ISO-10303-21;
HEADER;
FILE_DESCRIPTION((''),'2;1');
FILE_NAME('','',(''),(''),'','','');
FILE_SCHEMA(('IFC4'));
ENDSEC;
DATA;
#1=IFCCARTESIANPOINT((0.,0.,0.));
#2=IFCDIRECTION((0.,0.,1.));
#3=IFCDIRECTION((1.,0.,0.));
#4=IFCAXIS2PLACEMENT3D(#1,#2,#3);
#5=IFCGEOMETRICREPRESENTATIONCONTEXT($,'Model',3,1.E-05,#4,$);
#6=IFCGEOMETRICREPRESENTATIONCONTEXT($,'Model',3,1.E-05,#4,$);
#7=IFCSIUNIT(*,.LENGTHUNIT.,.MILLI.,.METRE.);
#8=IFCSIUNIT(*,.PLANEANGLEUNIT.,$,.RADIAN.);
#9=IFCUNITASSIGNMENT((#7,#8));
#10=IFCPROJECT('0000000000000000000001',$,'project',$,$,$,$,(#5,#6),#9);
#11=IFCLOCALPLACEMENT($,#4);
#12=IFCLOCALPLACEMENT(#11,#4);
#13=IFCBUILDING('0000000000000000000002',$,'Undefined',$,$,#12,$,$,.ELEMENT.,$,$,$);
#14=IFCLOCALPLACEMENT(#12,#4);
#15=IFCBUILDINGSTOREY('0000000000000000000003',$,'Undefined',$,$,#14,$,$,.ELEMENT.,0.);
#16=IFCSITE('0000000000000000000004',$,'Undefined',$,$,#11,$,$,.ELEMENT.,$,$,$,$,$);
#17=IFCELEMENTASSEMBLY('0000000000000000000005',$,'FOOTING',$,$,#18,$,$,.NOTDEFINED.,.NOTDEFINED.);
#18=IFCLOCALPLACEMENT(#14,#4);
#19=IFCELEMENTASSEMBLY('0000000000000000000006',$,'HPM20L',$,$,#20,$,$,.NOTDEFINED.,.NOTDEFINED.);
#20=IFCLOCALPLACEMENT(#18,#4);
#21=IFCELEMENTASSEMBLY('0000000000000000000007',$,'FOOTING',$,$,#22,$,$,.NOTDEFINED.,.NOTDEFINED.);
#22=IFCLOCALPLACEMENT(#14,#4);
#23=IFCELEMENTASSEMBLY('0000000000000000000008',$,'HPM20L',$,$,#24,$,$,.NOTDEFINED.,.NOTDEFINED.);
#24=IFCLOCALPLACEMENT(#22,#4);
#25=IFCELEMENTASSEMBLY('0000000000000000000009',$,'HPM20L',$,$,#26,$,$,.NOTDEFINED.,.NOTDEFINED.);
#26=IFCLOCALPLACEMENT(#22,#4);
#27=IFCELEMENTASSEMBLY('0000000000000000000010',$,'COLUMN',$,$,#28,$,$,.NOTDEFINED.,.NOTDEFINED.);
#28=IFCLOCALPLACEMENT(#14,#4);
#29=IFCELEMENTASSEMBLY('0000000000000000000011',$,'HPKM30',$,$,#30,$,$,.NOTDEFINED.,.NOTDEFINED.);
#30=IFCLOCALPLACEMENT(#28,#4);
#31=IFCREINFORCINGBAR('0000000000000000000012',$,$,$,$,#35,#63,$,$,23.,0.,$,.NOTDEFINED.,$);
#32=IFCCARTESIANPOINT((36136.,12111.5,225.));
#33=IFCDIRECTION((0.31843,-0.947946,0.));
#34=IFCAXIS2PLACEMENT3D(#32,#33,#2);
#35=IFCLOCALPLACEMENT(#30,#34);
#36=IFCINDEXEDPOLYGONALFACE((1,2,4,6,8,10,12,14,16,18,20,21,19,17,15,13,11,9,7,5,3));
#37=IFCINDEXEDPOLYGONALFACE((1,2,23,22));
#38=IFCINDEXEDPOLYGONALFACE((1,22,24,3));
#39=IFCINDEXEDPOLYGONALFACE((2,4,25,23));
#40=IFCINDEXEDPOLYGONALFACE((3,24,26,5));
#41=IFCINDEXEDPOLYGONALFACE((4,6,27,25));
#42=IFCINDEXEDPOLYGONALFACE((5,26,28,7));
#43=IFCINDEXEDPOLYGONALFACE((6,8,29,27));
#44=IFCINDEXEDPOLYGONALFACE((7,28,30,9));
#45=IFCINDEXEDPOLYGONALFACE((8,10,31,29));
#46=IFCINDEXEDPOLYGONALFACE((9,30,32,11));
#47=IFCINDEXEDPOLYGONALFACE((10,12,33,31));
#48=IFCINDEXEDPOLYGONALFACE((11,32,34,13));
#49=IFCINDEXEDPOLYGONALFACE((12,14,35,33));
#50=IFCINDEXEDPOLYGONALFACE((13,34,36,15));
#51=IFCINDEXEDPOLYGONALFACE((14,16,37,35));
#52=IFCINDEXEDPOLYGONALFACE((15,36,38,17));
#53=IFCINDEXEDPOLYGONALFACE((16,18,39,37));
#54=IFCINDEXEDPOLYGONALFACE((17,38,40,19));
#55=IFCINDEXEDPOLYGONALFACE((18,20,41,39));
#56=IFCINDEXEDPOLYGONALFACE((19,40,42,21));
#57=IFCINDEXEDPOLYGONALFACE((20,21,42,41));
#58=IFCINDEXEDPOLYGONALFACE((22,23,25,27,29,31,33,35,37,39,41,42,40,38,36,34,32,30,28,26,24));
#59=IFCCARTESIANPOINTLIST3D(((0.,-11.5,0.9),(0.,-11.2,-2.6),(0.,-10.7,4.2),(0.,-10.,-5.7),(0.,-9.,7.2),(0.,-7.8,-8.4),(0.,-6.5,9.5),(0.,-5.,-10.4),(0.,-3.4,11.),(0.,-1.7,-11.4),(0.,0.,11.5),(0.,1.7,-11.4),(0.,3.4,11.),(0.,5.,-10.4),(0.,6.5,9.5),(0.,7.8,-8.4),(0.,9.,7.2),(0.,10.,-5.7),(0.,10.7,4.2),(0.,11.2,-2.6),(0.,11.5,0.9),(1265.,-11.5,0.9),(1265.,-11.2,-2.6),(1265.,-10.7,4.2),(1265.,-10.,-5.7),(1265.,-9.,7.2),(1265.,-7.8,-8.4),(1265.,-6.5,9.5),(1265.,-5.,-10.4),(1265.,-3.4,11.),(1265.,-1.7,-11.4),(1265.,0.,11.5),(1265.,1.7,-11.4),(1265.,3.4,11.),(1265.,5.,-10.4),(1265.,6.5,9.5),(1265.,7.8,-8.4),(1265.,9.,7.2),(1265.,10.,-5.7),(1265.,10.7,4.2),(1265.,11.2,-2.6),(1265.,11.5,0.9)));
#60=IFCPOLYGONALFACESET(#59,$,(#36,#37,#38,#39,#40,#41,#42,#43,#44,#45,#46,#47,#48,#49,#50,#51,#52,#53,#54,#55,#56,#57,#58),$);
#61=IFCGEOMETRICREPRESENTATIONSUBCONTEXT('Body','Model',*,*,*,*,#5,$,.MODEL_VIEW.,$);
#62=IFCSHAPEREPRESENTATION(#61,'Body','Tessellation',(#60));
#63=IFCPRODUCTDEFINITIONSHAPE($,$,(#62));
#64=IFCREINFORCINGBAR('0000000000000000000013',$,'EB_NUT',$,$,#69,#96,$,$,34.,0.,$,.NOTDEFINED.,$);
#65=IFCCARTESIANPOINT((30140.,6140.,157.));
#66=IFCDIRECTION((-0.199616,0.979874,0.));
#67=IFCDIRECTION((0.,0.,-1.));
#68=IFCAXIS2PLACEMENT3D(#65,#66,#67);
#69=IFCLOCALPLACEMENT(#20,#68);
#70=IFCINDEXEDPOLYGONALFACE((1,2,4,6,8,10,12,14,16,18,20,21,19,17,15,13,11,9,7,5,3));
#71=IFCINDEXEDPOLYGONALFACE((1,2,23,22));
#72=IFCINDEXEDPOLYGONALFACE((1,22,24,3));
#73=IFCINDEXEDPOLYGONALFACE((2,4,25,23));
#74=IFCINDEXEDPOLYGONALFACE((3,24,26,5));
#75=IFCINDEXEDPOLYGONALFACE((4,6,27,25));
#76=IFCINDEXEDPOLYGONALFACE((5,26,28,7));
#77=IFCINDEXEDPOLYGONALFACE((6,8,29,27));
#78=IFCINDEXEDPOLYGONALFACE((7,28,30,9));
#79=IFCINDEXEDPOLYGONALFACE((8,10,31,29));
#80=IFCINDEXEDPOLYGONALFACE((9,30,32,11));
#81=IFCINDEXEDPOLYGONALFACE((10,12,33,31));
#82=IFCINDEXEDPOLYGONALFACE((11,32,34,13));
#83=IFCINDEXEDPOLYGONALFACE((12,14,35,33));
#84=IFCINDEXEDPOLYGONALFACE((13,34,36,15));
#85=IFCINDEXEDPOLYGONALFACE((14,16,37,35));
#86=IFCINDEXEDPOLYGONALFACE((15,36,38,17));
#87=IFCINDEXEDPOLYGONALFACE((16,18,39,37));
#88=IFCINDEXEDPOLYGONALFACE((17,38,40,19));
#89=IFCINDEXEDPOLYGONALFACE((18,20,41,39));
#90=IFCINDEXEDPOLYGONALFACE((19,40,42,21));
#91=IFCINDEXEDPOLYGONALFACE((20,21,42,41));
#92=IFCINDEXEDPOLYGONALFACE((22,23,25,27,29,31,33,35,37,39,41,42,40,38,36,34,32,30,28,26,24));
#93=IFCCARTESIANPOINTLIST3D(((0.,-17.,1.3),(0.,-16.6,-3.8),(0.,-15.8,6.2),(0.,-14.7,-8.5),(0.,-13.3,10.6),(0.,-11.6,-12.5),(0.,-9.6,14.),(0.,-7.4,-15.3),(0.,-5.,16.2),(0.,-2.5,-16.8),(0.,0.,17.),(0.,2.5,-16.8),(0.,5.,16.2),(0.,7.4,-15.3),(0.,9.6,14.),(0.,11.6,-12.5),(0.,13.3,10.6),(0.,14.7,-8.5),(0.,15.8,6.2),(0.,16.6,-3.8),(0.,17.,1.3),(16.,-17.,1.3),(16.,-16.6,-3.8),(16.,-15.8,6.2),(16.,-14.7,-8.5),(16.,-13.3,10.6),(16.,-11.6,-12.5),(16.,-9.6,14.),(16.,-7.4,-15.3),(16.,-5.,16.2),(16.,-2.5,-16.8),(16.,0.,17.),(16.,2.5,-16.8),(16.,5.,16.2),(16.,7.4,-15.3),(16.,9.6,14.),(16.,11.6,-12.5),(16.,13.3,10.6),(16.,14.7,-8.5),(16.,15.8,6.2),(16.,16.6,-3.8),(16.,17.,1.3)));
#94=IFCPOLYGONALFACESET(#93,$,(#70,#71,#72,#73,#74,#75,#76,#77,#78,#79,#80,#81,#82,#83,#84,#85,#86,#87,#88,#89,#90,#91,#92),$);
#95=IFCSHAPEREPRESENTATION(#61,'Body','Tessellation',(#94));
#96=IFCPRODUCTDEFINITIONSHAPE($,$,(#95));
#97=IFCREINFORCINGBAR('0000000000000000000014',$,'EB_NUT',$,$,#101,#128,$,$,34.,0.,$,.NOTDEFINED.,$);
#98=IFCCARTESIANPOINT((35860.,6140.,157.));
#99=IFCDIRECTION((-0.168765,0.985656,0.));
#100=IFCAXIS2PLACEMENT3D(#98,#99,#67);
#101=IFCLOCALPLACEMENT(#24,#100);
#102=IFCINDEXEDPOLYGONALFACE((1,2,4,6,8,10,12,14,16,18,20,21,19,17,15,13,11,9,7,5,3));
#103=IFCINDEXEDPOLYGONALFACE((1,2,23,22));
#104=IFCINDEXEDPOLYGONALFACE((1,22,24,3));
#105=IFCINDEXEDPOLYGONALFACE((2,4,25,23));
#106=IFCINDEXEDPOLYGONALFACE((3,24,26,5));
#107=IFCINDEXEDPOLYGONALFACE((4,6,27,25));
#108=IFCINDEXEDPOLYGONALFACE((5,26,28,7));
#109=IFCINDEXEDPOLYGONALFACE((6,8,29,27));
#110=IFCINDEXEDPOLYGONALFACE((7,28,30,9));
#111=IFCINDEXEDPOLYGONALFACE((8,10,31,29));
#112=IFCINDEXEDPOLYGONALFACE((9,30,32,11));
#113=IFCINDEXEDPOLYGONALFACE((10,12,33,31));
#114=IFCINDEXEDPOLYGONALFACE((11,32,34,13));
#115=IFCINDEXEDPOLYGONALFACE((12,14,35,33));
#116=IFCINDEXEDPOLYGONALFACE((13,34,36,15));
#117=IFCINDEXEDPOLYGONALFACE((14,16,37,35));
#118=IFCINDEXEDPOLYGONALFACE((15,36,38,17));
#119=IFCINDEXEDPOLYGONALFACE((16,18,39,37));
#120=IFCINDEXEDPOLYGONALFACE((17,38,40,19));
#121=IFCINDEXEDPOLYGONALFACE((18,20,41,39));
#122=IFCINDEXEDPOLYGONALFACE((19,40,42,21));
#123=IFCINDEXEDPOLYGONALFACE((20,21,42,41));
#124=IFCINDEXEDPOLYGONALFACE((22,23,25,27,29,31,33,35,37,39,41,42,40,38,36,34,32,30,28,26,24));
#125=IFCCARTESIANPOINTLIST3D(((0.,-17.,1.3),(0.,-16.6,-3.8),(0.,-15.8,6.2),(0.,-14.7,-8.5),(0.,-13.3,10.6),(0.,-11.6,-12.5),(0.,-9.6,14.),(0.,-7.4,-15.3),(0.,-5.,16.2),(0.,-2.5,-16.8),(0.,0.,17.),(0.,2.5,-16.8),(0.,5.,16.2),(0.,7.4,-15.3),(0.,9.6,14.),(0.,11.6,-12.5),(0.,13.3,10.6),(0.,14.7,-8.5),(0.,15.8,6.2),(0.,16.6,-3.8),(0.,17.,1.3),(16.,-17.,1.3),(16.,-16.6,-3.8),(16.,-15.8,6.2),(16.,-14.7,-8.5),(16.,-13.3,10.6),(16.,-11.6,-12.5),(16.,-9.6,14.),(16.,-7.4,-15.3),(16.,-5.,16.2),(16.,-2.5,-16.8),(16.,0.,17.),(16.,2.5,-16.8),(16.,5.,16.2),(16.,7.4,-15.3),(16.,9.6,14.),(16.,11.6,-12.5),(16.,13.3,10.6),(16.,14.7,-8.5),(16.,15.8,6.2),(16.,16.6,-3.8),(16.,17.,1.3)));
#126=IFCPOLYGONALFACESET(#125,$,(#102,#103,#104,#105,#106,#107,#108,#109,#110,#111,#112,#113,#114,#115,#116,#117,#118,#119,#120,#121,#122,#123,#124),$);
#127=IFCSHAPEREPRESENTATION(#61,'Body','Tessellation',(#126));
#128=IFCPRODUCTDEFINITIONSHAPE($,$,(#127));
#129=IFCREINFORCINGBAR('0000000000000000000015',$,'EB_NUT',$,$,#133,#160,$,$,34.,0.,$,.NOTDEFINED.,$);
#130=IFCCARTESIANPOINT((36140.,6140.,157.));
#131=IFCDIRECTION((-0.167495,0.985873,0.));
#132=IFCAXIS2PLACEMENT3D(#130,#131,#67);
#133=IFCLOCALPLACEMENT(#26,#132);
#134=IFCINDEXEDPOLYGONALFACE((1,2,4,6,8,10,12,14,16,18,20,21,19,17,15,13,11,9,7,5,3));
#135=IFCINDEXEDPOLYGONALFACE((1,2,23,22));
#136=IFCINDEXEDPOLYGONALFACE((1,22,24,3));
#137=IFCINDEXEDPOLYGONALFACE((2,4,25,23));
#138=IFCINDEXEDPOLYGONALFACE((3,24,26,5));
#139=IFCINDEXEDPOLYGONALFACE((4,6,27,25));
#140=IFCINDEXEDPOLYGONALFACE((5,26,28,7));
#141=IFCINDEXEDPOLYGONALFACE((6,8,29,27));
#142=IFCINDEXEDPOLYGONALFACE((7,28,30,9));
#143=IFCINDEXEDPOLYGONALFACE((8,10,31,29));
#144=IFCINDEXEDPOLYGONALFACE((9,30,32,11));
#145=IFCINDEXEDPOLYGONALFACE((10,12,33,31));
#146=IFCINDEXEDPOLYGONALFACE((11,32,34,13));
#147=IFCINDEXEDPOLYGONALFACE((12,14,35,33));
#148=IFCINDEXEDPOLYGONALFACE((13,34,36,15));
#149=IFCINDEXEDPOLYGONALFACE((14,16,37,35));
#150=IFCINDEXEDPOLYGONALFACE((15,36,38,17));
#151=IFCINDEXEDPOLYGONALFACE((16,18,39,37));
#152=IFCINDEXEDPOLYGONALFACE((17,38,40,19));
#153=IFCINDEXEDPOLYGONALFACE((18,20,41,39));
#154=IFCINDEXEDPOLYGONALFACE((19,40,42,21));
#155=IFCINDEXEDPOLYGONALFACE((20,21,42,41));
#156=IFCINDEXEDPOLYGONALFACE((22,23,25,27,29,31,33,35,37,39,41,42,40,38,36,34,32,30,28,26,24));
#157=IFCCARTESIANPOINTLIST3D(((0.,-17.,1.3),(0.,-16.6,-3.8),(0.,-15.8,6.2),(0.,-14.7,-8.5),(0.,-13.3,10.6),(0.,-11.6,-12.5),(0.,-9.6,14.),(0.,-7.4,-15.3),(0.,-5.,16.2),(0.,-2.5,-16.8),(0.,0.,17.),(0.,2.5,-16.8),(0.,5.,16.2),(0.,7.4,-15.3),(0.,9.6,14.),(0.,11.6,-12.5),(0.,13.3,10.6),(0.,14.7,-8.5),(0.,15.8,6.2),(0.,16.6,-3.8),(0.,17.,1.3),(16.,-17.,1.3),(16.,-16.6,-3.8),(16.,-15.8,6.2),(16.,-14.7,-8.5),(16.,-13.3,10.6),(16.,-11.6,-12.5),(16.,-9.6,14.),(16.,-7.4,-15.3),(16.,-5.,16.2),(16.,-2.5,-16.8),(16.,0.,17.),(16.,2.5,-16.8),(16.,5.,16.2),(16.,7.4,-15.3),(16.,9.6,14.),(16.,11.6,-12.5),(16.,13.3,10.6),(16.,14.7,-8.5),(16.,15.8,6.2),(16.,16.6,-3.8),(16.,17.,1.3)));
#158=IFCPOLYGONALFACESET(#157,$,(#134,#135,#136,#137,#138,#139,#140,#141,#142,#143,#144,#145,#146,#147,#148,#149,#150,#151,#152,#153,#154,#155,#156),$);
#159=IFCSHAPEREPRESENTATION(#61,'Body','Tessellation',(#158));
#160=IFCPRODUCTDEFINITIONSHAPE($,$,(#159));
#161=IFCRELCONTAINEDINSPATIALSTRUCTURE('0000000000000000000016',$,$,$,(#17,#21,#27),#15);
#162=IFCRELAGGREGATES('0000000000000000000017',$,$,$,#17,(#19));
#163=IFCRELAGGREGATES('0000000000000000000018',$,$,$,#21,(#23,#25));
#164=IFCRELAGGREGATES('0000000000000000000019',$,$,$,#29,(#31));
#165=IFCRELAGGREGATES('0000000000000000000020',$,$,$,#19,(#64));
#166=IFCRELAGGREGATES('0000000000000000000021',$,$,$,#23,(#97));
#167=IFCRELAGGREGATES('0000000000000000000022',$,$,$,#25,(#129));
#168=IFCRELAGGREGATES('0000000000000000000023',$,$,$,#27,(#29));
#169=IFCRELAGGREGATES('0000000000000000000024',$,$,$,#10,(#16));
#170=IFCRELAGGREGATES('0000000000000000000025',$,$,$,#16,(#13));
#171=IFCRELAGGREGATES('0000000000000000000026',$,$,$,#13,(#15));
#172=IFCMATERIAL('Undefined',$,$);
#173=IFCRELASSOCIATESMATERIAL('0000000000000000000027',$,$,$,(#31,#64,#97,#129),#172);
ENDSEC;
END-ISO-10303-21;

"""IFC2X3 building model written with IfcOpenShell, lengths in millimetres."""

from ifc_helpers import new_model, entity, si_unit, frame, origin_with_axes, place, context, subcontext, project, spatial, source, transform, mapped, material, element, aggregate, save


model = new_model("IFC2X3")

# Units and contexts
model_context_1 = context("Model", 3, precision=1e-05, world=origin_with_axes())
model_context_2 = context("Model", 3, precision=1e-05, world=origin_with_axes())
body_context = subcontext(model_context_1, "Body", "Model", "MODEL_VIEW")
ifc_project = project(units=[si_unit("LENGTHUNIT", "METRE", prefix="MILLI"), si_unit("PLANEANGLEUNIT", "RADIAN")], contexts=[model_context_1, model_context_2])

# Site, building, storey
site_placement = place(None, origin_with_axes())
site = spatial("IfcSite", under=ifc_project, at=site_placement, Name="Undefined", CompositionType="ELEMENT")
building_placement = place(site_placement, origin_with_axes())
building = spatial("IfcBuilding", under=site, at=building_placement, Name="Undefined", CompositionType="ELEMENT")
storey_placement = place(building_placement, origin_with_axes())
storey = spatial("IfcBuildingStorey", under=building, at=storey_placement, Name="Undefined", CompositionType="ELEMENT", Elevation=0.0)

# Element assemblies
assembly_1_placement = place(storey_placement, origin_with_axes())
assembly_1 = element("IfcElementAssembly", 1, at=assembly_1_placement, inside=storey, Name="FOOTING", AssemblyPlace="NOTDEFINED", PredefinedType="NOTDEFINED")
assembly_2_placement = place(assembly_1_placement, origin_with_axes())
assembly_2 = element("IfcElementAssembly", 2, at=assembly_2_placement, Name="HPM20L", AssemblyPlace="NOTDEFINED", PredefinedType="NOTDEFINED")
aggregate(assembly_1, [assembly_2])

# Element assemblies
assembly_3_placement = place(storey_placement, origin_with_axes())
assembly_3 = element("IfcElementAssembly", 3, at=assembly_3_placement, inside=storey, Name="FOOTING", AssemblyPlace="NOTDEFINED", PredefinedType="NOTDEFINED")
assembly_4_placement = place(assembly_3_placement, origin_with_axes())
assembly_4 = element("IfcElementAssembly", 4, at=assembly_4_placement, Name="HPM20L", AssemblyPlace="NOTDEFINED", PredefinedType="NOTDEFINED")
assembly_5_placement = place(assembly_3_placement, origin_with_axes())
assembly_5 = element("IfcElementAssembly", 5, at=assembly_5_placement, Name="HPM20L", AssemblyPlace="NOTDEFINED", PredefinedType="NOTDEFINED")
aggregate(assembly_3, [assembly_4, assembly_5])

# Element assembly
assembly_6_placement = place(storey_placement, origin_with_axes())
assembly_6 = element("IfcElementAssembly", 6, at=assembly_6_placement, inside=storey, Name="COLUMN", AssemblyPlace="NOTDEFINED", PredefinedType="NOTDEFINED")
ifc_material_1 = material(Name="Undefined")

# Element assembly, reinforcing bar
assembly_7_placement = place(assembly_6_placement, origin_with_axes())
assembly_7 = element("IfcElementAssembly", 7, at=assembly_7_placement, Name="HPKM30", AssemblyPlace="NOTDEFINED", PredefinedType="NOTDEFINED")
shared_shape_1 = source(origin_with_axes(), body_context, "Body", "AdvancedSweptSolid", [
    entity("IfcSweptDiskSolid", entity("IfcTrimmedCurve", entity("IfcLine", entity("IfcCartesianPoint", [0.0, 0.0, 0.0]), entity("IfcVector", entity("IfcDirection", [1.0, 0.0, 0.0]), 1.0)), [entity("IfcParameterValue", 0.0)], [entity("IfcParameterValue", 1265.0)], True, "PARAMETER"), 11.5, None, 0.0, 1265.0),
])
reinforcing_bar_1_placement = place(assembly_7_placement, frame((36136.0, 12111.5, 225.0), z_axis=(0.31843, -0.947946, 0.0), x_axis=(0.0, 0.0, 1.0)))
reinforcing_bar_1 = element("IfcReinforcingBar", 8, at=reinforcing_bar_1_placement, material=ifc_material_1, BarRole="NOTDEFINED", CrossSectionArea=0.0, NominalDiameter=23.0, context=body_context, shape_type="MappedRepresentation", body=[
    mapped(shared_shape_1, transform((0.0, 0.0, 0.0))),
])
aggregate(assembly_7, [reinforcing_bar_1])

# Reinforcing bars
shared_shape_2 = source(origin_with_axes(), body_context, "Body", "AdvancedSweptSolid", [
    entity("IfcSweptDiskSolid", entity("IfcTrimmedCurve", entity("IfcLine", entity("IfcCartesianPoint", [0.0, 0.0, 0.0]), entity("IfcVector", entity("IfcDirection", [1.0, 0.0, 0.0]), 1.0)), [entity("IfcParameterValue", 0.0)], [entity("IfcParameterValue", 16.0)], True, "PARAMETER"), 17.0, None, 0.0, 16.0),
])
reinforcing_bar_2_placement = place(assembly_2_placement, frame((30140.0, 6140.0, 157.0), z_axis=(-0.199616, 0.979874, 0.0), x_axis=(0.0, 0.0, -1.0)))
reinforcing_bar_2 = element("IfcReinforcingBar", 9, at=reinforcing_bar_2_placement, material=ifc_material_1, Name="EB_NUT", BarRole="NOTDEFINED", CrossSectionArea=0.0, NominalDiameter=34.0, context=body_context, shape_type="MappedRepresentation", body=[
    mapped(shared_shape_2, transform((0.0, 0.0, 0.0))),
])
aggregate(assembly_2, [reinforcing_bar_2])
shared_shape_3 = source(origin_with_axes(), body_context, "Body", "AdvancedSweptSolid", [
    entity("IfcSweptDiskSolid", entity("IfcTrimmedCurve", entity("IfcLine", entity("IfcCartesianPoint", [0.0, 0.0, 0.0]), entity("IfcVector", entity("IfcDirection", [1.0, 0.0, 0.0]), 1.0)), [entity("IfcParameterValue", 0.0)], [entity("IfcParameterValue", 16.0)], True, "PARAMETER"), 17.0, None, 0.0, 16.0),
])
reinforcing_bar_3_placement = place(assembly_4_placement, frame((35860.0, 6140.0, 157.0), z_axis=(-0.168765, 0.985656, 0.0), x_axis=(0.0, 0.0, -1.0)))
reinforcing_bar_3 = element("IfcReinforcingBar", 10, at=reinforcing_bar_3_placement, material=ifc_material_1, Name="EB_NUT", BarRole="NOTDEFINED", CrossSectionArea=0.0, NominalDiameter=34.0, context=body_context, shape_type="MappedRepresentation", body=[
    mapped(shared_shape_3, transform((0.0, 0.0, 0.0))),
])
aggregate(assembly_4, [reinforcing_bar_3])
shared_shape_4 = source(origin_with_axes(), body_context, "Body", "AdvancedSweptSolid", [
    entity("IfcSweptDiskSolid", entity("IfcTrimmedCurve", entity("IfcLine", entity("IfcCartesianPoint", [0.0, 0.0, 0.0]), entity("IfcVector", entity("IfcDirection", [1.0, 0.0, 0.0]), 1.0)), [entity("IfcParameterValue", 0.0)], [entity("IfcParameterValue", 16.0)], True, "PARAMETER"), 17.0, None, 0.0, 16.0),
])
reinforcing_bar_4_placement = place(assembly_5_placement, frame((36140.0, 6140.0, 157.0), z_axis=(-0.167495, 0.985873, 0.0), x_axis=(0.0, 0.0, -1.0)))
reinforcing_bar_4 = element("IfcReinforcingBar", 11, at=reinforcing_bar_4_placement, material=ifc_material_1, Name="EB_NUT", BarRole="NOTDEFINED", CrossSectionArea=0.0, NominalDiameter=34.0, context=body_context, shape_type="MappedRepresentation", body=[
    mapped(shared_shape_4, transform((0.0, 0.0, 0.0))),
])
aggregate(assembly_5, [reinforcing_bar_4])
aggregate(assembly_6, [assembly_7])

save(model, "model.ifc")
